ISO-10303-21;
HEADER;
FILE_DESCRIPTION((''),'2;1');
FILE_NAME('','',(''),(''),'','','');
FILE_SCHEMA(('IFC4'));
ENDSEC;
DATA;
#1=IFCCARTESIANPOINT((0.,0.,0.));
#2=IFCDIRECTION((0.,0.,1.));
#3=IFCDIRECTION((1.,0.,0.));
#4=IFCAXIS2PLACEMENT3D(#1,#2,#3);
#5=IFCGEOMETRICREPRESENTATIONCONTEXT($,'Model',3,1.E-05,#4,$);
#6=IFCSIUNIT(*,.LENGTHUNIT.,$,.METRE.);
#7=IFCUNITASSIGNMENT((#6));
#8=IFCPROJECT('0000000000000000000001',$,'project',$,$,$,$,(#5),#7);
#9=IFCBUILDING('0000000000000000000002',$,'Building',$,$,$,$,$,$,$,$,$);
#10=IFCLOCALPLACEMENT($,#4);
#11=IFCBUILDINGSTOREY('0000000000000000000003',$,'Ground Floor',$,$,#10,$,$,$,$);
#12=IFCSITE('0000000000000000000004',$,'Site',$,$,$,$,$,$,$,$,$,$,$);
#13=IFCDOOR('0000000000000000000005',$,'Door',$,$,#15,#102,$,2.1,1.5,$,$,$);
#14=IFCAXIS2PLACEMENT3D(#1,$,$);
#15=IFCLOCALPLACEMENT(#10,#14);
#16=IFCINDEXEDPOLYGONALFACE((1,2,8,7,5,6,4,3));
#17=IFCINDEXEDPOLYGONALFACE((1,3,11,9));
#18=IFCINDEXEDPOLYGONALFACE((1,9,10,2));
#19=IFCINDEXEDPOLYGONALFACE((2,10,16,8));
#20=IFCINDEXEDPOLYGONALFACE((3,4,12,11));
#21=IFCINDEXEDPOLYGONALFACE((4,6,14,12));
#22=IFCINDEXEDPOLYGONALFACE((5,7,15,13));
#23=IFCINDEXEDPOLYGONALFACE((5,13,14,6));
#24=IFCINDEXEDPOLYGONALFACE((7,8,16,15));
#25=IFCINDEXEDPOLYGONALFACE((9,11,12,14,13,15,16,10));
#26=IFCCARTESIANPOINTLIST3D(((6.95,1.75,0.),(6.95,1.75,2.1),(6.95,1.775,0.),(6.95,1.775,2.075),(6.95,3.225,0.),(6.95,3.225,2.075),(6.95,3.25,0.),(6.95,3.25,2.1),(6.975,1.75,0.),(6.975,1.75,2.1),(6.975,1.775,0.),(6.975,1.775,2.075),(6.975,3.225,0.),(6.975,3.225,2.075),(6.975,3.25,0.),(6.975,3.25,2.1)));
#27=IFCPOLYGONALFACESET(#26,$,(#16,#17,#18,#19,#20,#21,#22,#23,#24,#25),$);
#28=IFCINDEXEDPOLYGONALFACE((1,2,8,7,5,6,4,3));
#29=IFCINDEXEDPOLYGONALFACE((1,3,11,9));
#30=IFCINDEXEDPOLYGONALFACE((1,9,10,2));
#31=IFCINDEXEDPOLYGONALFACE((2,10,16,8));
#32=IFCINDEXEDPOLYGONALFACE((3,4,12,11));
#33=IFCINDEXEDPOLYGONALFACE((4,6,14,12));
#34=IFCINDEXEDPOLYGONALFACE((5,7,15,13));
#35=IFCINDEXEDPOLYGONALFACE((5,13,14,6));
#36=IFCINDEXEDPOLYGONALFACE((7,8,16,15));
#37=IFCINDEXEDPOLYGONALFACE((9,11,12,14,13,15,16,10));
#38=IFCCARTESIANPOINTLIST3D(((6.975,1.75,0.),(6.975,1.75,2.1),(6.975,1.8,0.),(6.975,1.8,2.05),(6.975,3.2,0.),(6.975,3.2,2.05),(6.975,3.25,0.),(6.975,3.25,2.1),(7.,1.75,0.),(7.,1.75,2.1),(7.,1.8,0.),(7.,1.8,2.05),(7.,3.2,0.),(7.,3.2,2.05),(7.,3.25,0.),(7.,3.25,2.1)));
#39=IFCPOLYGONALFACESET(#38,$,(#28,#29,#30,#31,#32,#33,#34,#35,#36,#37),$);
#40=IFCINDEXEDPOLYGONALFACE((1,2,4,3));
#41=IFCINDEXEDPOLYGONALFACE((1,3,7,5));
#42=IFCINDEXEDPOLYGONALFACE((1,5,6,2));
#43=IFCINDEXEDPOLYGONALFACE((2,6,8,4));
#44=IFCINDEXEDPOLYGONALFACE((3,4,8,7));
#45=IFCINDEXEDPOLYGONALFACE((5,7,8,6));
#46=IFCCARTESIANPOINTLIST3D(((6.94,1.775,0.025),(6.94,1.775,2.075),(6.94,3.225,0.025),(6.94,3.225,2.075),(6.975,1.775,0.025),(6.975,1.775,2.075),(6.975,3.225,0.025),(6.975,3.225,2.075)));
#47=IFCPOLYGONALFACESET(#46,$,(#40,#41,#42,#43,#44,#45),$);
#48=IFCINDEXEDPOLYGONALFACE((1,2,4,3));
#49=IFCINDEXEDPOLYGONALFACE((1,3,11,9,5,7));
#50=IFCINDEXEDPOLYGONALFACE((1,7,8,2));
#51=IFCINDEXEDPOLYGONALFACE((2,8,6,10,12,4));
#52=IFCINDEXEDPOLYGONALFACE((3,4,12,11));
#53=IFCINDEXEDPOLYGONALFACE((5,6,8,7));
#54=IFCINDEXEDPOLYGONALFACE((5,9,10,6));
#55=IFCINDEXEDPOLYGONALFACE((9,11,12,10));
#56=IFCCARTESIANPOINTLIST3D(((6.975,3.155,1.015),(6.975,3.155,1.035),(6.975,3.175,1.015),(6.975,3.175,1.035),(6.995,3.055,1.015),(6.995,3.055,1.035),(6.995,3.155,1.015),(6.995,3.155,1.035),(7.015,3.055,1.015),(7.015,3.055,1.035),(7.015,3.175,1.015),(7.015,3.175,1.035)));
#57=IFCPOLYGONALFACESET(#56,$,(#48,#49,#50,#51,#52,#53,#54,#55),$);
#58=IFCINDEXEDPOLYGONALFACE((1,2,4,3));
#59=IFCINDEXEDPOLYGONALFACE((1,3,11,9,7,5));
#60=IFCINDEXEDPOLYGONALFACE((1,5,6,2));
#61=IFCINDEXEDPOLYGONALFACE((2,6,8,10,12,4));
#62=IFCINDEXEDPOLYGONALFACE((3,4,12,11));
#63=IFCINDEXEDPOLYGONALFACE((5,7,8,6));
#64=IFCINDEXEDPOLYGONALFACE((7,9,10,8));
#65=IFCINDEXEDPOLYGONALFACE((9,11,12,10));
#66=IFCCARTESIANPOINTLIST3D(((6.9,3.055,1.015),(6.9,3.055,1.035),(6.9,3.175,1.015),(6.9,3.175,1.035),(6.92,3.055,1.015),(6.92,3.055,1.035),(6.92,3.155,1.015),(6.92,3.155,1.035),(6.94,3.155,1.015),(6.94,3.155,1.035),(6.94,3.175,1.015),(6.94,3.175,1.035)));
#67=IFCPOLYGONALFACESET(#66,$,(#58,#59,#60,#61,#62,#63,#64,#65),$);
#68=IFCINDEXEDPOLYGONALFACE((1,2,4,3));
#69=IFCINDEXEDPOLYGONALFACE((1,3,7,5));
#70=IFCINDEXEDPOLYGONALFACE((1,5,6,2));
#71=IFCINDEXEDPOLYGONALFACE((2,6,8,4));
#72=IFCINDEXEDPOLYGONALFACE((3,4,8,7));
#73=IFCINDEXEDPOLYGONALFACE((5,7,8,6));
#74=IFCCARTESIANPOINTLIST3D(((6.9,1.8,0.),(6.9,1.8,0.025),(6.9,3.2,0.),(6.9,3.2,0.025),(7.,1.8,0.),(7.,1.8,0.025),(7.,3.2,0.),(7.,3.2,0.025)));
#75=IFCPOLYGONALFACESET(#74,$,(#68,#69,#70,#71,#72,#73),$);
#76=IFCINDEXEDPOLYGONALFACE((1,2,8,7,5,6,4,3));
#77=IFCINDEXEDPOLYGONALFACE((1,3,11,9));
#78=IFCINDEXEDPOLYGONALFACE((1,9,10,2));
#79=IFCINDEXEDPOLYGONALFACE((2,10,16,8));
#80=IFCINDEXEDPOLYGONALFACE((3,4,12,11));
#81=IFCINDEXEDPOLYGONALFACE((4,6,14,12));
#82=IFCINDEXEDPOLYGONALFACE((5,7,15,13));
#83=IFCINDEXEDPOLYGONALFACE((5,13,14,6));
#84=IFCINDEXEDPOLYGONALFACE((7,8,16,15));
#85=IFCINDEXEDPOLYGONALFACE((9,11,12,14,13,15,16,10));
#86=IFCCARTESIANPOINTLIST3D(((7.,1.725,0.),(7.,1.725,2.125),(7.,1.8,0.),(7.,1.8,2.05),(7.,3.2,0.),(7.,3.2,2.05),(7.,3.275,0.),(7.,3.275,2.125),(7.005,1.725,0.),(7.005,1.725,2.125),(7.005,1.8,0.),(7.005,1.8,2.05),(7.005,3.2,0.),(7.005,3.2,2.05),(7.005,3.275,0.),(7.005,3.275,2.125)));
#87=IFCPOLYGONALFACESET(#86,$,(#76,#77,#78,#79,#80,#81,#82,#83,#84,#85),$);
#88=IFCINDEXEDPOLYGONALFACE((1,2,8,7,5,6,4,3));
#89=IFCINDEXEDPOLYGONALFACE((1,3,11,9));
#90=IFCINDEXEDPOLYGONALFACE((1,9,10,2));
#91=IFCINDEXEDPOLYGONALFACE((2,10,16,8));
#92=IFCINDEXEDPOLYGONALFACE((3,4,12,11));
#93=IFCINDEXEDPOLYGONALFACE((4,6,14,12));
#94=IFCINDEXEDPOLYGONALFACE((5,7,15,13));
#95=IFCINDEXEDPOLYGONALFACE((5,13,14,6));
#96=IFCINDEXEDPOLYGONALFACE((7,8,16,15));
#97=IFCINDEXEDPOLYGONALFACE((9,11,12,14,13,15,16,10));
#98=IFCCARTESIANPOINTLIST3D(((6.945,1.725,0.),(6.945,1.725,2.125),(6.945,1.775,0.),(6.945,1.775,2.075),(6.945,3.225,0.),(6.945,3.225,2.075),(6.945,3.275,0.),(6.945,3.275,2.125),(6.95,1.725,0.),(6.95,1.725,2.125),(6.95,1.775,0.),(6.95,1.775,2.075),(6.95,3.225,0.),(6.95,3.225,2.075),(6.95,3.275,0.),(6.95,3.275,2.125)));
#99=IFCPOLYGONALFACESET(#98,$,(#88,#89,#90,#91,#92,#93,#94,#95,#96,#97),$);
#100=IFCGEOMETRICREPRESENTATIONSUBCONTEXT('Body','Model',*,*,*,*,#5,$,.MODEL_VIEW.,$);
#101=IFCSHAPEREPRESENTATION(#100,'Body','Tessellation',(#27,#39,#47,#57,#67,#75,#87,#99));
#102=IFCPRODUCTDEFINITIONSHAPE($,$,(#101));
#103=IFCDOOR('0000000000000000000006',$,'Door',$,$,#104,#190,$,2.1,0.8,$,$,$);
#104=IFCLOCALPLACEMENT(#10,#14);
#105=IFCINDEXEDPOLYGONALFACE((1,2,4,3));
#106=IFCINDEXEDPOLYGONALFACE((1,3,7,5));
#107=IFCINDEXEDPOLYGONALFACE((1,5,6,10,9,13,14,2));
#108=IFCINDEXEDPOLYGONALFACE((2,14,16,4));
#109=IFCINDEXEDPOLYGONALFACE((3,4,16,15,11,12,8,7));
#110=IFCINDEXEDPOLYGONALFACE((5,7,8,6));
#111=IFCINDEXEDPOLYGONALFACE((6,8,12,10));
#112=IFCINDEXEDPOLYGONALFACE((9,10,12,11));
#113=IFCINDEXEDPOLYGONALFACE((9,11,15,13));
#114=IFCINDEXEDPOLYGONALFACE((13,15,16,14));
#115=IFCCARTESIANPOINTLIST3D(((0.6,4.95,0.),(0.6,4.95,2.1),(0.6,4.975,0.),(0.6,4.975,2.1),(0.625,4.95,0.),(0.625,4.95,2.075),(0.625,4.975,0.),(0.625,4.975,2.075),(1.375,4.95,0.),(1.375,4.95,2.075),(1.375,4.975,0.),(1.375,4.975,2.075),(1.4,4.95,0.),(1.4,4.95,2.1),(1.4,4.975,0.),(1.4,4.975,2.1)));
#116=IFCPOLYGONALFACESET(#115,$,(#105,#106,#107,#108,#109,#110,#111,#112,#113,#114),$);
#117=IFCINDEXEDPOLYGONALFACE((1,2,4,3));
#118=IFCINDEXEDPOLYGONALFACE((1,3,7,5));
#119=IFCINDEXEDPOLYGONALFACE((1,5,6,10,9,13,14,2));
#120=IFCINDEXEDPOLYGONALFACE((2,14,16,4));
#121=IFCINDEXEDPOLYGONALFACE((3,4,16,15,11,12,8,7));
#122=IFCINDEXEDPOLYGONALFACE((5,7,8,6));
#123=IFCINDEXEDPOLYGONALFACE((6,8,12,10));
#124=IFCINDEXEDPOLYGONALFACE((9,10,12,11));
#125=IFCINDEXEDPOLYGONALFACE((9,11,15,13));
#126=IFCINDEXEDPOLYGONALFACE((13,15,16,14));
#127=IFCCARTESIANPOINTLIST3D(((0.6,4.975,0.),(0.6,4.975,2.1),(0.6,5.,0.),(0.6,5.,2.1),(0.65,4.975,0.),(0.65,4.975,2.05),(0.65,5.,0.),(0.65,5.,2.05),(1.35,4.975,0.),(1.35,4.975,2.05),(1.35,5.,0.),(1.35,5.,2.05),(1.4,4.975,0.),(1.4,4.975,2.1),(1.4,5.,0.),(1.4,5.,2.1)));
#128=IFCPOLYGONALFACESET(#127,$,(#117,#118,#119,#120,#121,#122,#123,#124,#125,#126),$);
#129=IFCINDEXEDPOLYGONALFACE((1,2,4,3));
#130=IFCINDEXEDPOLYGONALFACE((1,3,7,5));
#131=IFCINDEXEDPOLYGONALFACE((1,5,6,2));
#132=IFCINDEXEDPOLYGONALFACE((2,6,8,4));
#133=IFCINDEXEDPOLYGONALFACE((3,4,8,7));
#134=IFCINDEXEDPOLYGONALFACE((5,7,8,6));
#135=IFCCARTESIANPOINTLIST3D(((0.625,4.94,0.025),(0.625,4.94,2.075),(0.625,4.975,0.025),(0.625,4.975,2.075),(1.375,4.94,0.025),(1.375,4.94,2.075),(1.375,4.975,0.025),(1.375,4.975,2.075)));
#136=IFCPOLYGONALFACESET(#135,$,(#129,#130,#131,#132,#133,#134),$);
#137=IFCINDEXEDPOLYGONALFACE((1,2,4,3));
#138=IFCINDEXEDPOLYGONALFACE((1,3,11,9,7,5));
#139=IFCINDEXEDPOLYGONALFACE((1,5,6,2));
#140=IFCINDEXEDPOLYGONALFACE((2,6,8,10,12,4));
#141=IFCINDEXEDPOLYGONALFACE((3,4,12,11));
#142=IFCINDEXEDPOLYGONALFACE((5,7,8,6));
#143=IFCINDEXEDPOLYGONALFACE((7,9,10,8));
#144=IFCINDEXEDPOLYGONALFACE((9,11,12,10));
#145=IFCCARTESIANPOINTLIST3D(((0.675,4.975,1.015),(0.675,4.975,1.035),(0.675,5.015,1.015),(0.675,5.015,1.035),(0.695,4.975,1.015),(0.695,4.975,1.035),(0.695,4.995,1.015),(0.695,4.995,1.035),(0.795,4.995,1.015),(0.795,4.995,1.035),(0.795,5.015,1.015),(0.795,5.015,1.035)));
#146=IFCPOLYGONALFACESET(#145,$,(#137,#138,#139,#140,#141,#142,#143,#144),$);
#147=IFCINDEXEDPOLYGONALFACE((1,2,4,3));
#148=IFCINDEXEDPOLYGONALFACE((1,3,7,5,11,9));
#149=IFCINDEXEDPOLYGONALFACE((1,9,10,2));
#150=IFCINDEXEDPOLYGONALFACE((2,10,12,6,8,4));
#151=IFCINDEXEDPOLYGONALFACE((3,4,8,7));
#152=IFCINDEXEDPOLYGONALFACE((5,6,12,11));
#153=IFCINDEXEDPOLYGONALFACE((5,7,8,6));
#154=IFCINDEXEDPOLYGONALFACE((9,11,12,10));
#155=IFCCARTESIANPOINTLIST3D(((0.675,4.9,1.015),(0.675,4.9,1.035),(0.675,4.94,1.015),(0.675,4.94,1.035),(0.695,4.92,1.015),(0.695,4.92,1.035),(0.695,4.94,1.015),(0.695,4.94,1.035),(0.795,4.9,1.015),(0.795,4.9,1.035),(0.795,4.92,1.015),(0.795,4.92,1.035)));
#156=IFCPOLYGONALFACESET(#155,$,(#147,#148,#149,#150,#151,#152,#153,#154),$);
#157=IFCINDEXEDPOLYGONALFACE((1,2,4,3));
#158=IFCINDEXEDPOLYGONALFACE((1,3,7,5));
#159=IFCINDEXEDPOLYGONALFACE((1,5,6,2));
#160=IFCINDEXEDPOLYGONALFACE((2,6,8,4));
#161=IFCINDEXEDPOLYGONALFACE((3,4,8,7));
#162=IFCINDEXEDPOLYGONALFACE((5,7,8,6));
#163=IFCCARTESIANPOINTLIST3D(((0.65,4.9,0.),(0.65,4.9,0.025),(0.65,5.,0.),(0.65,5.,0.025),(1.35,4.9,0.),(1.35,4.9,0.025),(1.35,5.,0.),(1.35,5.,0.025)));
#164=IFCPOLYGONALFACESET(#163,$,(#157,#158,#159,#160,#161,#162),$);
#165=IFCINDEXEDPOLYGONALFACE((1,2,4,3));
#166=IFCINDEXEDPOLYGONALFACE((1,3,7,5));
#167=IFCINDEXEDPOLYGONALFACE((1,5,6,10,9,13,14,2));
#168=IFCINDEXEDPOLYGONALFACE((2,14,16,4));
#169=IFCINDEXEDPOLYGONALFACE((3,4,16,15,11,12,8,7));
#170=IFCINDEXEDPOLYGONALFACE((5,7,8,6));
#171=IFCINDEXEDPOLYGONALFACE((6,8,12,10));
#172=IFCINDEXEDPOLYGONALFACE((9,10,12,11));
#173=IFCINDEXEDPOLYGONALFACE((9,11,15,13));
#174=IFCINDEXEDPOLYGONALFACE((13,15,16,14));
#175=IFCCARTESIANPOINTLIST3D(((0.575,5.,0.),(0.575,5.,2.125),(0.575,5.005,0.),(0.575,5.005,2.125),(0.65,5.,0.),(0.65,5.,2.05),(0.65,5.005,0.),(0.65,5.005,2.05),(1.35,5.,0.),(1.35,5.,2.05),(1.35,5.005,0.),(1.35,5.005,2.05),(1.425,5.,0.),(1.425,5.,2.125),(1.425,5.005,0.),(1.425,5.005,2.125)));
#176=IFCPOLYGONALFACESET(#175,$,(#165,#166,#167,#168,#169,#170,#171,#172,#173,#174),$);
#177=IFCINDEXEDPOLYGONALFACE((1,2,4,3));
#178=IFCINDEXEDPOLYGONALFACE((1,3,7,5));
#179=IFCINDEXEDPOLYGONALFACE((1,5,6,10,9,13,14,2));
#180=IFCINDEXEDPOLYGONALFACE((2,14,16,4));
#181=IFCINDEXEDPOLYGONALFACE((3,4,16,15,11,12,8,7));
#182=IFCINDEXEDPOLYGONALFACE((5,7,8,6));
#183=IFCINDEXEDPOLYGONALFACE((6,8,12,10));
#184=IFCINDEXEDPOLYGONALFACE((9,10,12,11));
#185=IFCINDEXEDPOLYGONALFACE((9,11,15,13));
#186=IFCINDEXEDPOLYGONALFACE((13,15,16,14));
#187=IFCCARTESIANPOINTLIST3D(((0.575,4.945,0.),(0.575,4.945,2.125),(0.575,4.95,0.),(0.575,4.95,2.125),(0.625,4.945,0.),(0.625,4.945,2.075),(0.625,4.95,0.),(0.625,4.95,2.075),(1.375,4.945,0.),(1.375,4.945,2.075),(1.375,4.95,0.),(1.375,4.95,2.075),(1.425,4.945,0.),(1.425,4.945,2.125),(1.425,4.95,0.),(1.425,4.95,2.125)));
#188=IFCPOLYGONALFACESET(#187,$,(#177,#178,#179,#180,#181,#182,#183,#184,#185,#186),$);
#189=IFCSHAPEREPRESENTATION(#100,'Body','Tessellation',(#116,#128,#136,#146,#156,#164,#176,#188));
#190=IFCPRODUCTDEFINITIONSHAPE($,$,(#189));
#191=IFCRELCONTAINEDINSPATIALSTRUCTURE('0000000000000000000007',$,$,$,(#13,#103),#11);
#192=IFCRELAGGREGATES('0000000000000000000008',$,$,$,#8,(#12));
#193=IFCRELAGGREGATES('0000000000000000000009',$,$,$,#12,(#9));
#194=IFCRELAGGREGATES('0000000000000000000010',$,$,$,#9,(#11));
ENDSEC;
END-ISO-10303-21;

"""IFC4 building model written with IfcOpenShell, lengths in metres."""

from ifc_helpers import new_model, si_unit, frame, origin_with_axes, place, context, subcontext, project, spatial, line, indexed_curve, outline, extrude, element, save


model = new_model("IFC4")

# Units and contexts
model_context = context("Model", 3, precision=1e-05, world=origin_with_axes())
body_context = subcontext(model_context, "Body", "Model", "MODEL_VIEW")
ifc_project = project(units=[si_unit("LENGTHUNIT", "METRE")], contexts=[model_context])

# Site, building, storey
site = spatial("IfcSite", under=ifc_project, Name="Site")
building = spatial("IfcBuilding", under=site, Name="Building")
storey_placement = place(None, origin_with_axes())
storey = spatial("IfcBuildingStorey", under=building, at=storey_placement, Name="Ground Floor")

# Doors
door_1_placement = place(storey_placement, frame((7.0, 1.75, 0.0), z_axis=(0.0, 0.0, 1.0), x_axis=(0.0, 1.0, 0.0)))
element("IfcDoor", 1, at=door_1_placement, inside=storey, Name="Door", OverallHeight=2.1, OverallWidth=1.5, context=body_context, shape_type="SweptSolid", body=[
    extrude(outline(indexed_curve([(0.0, 0.0), (0.0, 2.1), (1.5, 2.1), (1.5, 0.0), (1.475, 0.0), (1.475, 2.075), (0.025, 2.075), (0.025, 0.0)], segments=[line(1, 2, 3, 4, 5, 6, 7, 8, 1)])), frame((0.0, 0.025, 0.0), z_axis=(0.0, -1.0, 0.0), x_axis=(1.0, 0.0, 0.0)), (0.0, 0.0, -1.0), 0.025),
    extrude(outline(indexed_curve([(0.0, 0.0), (0.0, 2.1), (1.5, 2.1), (1.5, 0.0), (1.45, 0.0), (1.45, 2.05), (0.05, 2.05), (0.05, 0.0)], segments=[line(1, 2, 3, 4, 5, 6, 7, 8, 1)])), frame((0.0, 0.0, 0.0), z_axis=(0.0, -1.0, 0.0), x_axis=(1.0, 0.0, 0.0)), (0.0, 0.0, -1.0), 0.025),
    extrude(outline(indexed_curve([(0.0, 0.0), (1.45, 0.0), (1.45, 0.035), (0.0, 0.035)], segments=[line(1, 2, 3, 4, 1)])), frame((0.025, 0.025, 0.025), z_axis=(0.0, 0.0, 1.0), x_axis=(1.0, 0.0, 0.0)), (0.0, 0.0, 1.0), 2.05),
    extrude(outline(indexed_curve([(0.0, 0.0), (0.0, -0.04), (-0.12, -0.04), (-0.12, -0.02), (-0.02, -0.02), (-0.02, 0.0)], segments=[line(1, 2, 3, 4, 5, 6, 1)])), frame((1.425, 0.025, 1.015), z_axis=(0.0, 0.0, 1.0), x_axis=(1.0, 0.0, 0.0)), (0.0, 0.0, 1.0), 0.02),
    extrude(outline(indexed_curve([(0.0, 0.0), (0.0, 0.04), (-0.12, 0.04), (-0.12, 0.02), (-0.02, 0.02), (-0.02, 0.0)], segments=[line(1, 2, 3, 4, 5, 6, 1)])), frame((1.425, 0.06, 1.015), z_axis=(0.0, 0.0, 1.0), x_axis=(1.0, 0.0, 0.0)), (0.0, 0.0, 1.0), 0.02),
    extrude(outline(indexed_curve([(0.0, 0.0), (1.4, 0.0), (1.4, 0.1), (0.0, 0.1)], segments=[line(1, 2, 3, 4, 1)])), frame((0.05, 0.0, 0.0), z_axis=(0.0, 0.0, 1.0), x_axis=(1.0, 0.0, 0.0)), (0.0, 0.0, 1.0), 0.025),
    extrude(outline(indexed_curve([(0.0, 0.0), (0.0, 2.125), (1.55, 2.125), (1.55, 0.0), (1.475, 0.0), (1.475, 2.05), (0.075, 2.05), (0.075, 0.0)], segments=[line(1, 2, 3, 4, 5, 6, 7, 8, 1)])), frame((-0.025, -0.005, 0.0), z_axis=(0.0, -1.0, 0.0), x_axis=(1.0, 0.0, 0.0)), (0.0, 0.0, -1.0), 0.005),
    extrude(outline(indexed_curve([(0.0, 0.0), (0.0, 2.125), (1.55, 2.125), (1.55, 0.0), (1.5, 0.0), (1.5, 2.075), (0.05, 2.075), (0.05, 0.0)], segments=[line(1, 2, 3, 4, 5, 6, 7, 8, 1)])), frame((-0.025, 0.05, 0.0), z_axis=(0.0, -1.0, 0.0), x_axis=(1.0, 0.0, 0.0)), (0.0, 0.0, -1.0), 0.005),
])
door_2_placement = place(storey_placement, frame((1.4, 5.0, 0.0), z_axis=(0.0, 0.0, 1.0), x_axis=(-1.0, 0.0, 0.0)))
element("IfcDoor", 2, at=door_2_placement, inside=storey, Name="Door", OverallHeight=2.1, OverallWidth=0.8, context=body_context, shape_type="SweptSolid", body=[
    extrude(outline(indexed_curve([(0.0, 0.0), (0.0, 2.1), (0.8, 2.1), (0.8, 0.0), (0.775, 0.0), (0.775, 2.075), (0.025, 2.075), (0.025, 0.0)], segments=[line(1, 2, 3, 4, 5, 6, 7, 8, 1)])), frame((0.0, 0.025, 0.0), z_axis=(0.0, -1.0, 0.0), x_axis=(1.0, 0.0, 0.0)), (0.0, 0.0, -1.0), 0.025),
    extrude(outline(indexed_curve([(0.0, 0.0), (0.0, 2.1), (0.8, 2.1), (0.8, 0.0), (0.75, 0.0), (0.75, 2.05), (0.05, 2.05), (0.05, 0.0)], segments=[line(1, 2, 3, 4, 5, 6, 7, 8, 1)])), frame((0.0, 0.0, 0.0), z_axis=(0.0, -1.0, 0.0), x_axis=(1.0, 0.0, 0.0)), (0.0, 0.0, -1.0), 0.025),
    extrude(outline(indexed_curve([(0.0, 0.0), (0.75, 0.0), (0.75, 0.035), (0.0, 0.035)], segments=[line(1, 2, 3, 4, 1)])), frame((0.025, 0.025, 0.025), z_axis=(0.0, 0.0, 1.0), x_axis=(1.0, 0.0, 0.0)), (0.0, 0.0, 1.0), 2.05),
    extrude(outline(indexed_curve([(0.0, 0.0), (0.0, -0.04), (-0.12, -0.04), (-0.12, -0.02), (-0.02, -0.02), (-0.02, 0.0)], segments=[line(1, 2, 3, 4, 5, 6, 1)])), frame((0.725, 0.025, 1.015), z_axis=(0.0, 0.0, 1.0), x_axis=(1.0, 0.0, 0.0)), (0.0, 0.0, 1.0), 0.02),
    extrude(outline(indexed_curve([(0.0, 0.0), (0.0, 0.04), (-0.12, 0.04), (-0.12, 0.02), (-0.02, 0.02), (-0.02, 0.0)], segments=[line(1, 2, 3, 4, 5, 6, 1)])), frame((0.725, 0.06, 1.015), z_axis=(0.0, 0.0, 1.0), x_axis=(1.0, 0.0, 0.0)), (0.0, 0.0, 1.0), 0.02),
    extrude(outline(indexed_curve([(0.0, 0.0), (0.7, 0.0), (0.7, 0.1), (0.0, 0.1)], segments=[line(1, 2, 3, 4, 1)])), frame((0.05, 0.0, 0.0), z_axis=(0.0, 0.0, 1.0), x_axis=(1.0, 0.0, 0.0)), (0.0, 0.0, 1.0), 0.025),
    extrude(outline(indexed_curve([(0.0, 0.0), (0.0, 2.125), (0.85, 2.125), (0.85, 0.0), (0.775, 0.0), (0.775, 2.05), (0.075, 2.05), (0.075, 0.0)], segments=[line(1, 2, 3, 4, 5, 6, 7, 8, 1)])), frame((-0.025, -0.005, 0.0), z_axis=(0.0, -1.0, 0.0), x_axis=(1.0, 0.0, 0.0)), (0.0, 0.0, -1.0), 0.005),
    extrude(outline(indexed_curve([(0.0, 0.0), (0.0, 2.125), (0.85, 2.125), (0.85, 0.0), (0.8, 0.0), (0.8, 2.075), (0.05, 2.075), (0.05, 0.0)], segments=[line(1, 2, 3, 4, 5, 6, 7, 8, 1)])), frame((-0.025, 0.05, 0.0), z_axis=(0.0, -1.0, 0.0), x_axis=(1.0, 0.0, 0.0)), (0.0, 0.0, -1.0), 0.005),
])

save(model, "model.ifc")
